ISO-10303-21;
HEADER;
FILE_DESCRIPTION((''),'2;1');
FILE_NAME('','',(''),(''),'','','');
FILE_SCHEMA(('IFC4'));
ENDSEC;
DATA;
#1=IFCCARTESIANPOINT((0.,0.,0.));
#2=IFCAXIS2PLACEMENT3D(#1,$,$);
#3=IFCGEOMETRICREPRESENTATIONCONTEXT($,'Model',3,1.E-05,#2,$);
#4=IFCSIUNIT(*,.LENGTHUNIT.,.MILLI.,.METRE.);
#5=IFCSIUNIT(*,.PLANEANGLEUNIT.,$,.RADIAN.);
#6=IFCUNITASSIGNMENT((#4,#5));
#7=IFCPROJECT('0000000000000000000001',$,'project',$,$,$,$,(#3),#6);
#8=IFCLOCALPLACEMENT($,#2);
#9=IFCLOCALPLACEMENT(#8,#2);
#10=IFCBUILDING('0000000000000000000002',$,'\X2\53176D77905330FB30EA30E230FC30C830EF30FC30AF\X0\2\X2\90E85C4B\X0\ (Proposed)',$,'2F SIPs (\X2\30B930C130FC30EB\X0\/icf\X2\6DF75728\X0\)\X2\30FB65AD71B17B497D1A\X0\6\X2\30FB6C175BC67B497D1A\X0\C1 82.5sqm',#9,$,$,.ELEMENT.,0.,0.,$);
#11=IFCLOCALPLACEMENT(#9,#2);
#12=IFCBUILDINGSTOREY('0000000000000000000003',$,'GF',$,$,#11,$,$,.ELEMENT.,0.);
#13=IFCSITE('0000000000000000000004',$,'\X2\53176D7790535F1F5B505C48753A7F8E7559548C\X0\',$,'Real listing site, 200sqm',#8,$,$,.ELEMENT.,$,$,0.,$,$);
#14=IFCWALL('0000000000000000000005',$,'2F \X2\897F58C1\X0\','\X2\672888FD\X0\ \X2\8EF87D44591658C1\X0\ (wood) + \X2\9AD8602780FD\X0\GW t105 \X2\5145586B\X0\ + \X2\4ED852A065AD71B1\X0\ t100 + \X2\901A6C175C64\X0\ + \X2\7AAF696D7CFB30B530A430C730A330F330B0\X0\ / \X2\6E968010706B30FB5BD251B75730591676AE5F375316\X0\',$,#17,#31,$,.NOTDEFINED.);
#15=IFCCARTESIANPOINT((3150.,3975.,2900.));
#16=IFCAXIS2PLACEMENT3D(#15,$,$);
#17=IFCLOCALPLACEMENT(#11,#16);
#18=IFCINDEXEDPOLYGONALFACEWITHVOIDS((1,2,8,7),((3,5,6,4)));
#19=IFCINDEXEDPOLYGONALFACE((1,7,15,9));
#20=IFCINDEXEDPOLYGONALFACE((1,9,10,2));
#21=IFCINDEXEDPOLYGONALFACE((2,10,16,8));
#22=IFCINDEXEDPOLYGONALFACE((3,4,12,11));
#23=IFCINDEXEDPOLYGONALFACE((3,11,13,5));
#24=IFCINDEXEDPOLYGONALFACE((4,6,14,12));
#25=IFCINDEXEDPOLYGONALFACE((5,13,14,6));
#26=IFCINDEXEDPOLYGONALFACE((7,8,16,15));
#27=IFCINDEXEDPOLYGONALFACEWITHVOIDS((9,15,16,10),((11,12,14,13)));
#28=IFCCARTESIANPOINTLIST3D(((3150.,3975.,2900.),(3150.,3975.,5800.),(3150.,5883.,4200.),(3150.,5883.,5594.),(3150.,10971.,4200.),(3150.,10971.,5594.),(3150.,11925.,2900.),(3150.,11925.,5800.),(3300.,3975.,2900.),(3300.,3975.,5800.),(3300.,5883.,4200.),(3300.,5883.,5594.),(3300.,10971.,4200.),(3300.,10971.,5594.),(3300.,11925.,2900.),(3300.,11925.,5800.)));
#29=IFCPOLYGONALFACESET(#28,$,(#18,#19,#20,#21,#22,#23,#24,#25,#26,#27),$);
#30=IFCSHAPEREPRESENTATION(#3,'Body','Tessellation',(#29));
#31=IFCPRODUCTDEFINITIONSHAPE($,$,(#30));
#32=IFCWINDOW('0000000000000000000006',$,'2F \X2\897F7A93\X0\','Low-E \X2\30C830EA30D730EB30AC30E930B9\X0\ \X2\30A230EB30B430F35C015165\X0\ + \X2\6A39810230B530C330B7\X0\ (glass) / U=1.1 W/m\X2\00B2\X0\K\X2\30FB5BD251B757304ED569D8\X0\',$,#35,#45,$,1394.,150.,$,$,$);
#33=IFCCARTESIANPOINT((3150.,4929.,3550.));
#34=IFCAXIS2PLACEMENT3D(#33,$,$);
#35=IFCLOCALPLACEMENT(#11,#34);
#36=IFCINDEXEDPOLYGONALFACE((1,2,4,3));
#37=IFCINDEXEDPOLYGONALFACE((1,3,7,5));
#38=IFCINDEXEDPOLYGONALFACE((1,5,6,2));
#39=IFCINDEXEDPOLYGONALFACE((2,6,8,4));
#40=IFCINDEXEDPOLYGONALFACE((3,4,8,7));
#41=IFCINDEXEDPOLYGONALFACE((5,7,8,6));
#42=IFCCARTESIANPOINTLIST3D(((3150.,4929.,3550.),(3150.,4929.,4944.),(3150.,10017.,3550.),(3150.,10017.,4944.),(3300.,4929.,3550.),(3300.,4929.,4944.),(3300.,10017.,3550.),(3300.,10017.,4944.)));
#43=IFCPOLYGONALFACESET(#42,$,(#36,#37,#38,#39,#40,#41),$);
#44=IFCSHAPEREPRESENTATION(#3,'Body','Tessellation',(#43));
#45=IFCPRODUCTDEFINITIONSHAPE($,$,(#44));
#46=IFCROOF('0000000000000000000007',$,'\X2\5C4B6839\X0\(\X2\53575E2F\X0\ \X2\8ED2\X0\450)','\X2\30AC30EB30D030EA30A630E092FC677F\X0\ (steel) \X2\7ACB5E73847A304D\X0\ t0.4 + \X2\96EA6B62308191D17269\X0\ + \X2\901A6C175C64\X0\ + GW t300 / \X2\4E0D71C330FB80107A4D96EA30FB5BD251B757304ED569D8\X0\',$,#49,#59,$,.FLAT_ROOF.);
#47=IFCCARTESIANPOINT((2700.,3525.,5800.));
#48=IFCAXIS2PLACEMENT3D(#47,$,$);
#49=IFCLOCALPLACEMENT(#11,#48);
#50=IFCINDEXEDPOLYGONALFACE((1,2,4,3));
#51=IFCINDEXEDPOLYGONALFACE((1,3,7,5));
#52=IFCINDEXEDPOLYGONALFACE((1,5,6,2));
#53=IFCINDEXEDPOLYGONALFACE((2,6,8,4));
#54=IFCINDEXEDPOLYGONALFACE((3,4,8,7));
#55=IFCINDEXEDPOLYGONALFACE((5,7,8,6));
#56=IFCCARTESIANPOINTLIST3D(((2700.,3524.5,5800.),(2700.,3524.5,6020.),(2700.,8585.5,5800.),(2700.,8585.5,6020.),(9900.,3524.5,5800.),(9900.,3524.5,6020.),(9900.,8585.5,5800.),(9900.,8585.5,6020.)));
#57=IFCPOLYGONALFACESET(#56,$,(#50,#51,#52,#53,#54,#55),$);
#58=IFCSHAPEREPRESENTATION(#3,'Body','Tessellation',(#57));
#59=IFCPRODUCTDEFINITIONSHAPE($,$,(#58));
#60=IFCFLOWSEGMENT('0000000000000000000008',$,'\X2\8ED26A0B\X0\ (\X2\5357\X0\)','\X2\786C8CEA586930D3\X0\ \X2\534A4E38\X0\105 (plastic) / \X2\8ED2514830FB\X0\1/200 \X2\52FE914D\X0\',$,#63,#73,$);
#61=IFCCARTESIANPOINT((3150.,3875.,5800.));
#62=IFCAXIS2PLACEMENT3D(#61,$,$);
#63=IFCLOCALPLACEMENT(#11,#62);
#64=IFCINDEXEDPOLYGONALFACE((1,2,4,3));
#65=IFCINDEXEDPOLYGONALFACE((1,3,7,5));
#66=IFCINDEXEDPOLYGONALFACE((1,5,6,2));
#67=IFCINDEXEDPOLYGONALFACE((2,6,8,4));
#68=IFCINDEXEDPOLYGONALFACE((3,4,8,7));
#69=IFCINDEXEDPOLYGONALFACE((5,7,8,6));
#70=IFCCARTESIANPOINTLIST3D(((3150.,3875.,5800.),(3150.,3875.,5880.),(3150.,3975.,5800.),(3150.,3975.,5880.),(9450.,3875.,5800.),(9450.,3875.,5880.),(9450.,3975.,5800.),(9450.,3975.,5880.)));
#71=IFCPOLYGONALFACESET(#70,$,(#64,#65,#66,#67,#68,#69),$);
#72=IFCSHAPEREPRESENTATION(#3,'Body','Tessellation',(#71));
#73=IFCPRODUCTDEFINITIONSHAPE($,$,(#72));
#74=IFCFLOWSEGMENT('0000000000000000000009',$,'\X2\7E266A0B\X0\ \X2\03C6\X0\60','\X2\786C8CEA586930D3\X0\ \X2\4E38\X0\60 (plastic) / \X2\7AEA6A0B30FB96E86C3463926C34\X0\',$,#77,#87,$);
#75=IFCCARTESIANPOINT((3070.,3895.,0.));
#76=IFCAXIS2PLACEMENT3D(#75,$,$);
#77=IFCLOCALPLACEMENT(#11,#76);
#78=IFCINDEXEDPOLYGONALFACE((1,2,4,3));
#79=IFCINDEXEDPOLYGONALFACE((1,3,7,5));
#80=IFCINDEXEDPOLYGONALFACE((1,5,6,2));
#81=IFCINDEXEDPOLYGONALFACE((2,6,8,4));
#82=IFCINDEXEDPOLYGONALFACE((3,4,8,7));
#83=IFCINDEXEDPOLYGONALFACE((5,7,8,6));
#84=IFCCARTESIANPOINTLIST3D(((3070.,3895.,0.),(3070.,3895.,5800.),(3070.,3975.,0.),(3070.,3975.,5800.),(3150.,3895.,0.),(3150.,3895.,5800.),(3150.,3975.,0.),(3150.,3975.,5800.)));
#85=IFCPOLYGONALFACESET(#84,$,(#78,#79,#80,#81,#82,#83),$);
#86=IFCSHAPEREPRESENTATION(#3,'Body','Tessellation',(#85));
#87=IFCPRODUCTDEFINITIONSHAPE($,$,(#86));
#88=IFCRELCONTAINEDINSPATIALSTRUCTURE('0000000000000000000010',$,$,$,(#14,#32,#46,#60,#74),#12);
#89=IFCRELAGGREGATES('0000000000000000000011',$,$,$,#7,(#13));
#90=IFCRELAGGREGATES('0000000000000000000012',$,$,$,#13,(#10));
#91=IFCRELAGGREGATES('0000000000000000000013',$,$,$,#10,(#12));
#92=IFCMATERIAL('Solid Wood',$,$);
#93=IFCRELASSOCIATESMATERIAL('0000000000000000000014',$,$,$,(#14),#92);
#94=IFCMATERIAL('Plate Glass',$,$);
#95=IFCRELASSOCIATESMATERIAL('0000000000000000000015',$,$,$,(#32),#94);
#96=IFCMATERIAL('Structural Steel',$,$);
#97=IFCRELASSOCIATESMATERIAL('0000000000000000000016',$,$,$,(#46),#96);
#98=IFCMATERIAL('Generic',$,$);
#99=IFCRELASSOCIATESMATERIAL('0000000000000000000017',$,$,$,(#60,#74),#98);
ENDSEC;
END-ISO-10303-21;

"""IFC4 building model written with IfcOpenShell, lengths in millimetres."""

from ifc_helpers import new_model, si_unit, frame, frame_2d, origin, place, context, project, spatial, rectangle, extrude, material, element, fill, save


model = new_model("IFC4")

# Units and contexts
model_context = context("Model", 3, precision=1e-05, world=origin())
ifc_project = project(units=[si_unit("LENGTHUNIT", "METRE", prefix="MILLI"), si_unit("PLANEANGLEUNIT", "RADIAN")], contexts=[model_context])

# Site, building, storey
site_placement = place(None, origin())
site = spatial("IfcSite", under=ifc_project, at=site_placement, Name="北海道弟子屈町美留和", ObjectType="Real listing site, 200sqm", CompositionType="ELEMENT", RefElevation=0.0)
building_placement = place(site_placement, origin())
building = spatial("IfcBuilding", under=site, at=building_placement, Name="北海道・リモートワーク2部屋 (Proposed)", ObjectType="2F SIPs (スチール/icf混在)・断熱等級6・気密等級C1 82.5sqm", CompositionType="ELEMENT", ElevationOfRefHeight=0.0, ElevationOfTerrain=0.0)
storey_placement = place(building_placement, origin())
storey = spatial("IfcBuildingStorey", under=building, at=storey_placement, Name="GF", CompositionType="ELEMENT", Elevation=0.0)

# Shared definitions
ifc_material_1 = material(Name="Solid Wood")

# Shared definitions
ifc_material_2 = material(Name="Plate Glass")

# Wall, opening, window
wall_1_placement = place(storey_placement, frame((3150.0, 3975.0, 2900.0)))
wall_1 = element("IfcWall", 1, at=wall_1_placement, inside=storey, material=ifc_material_1, Name="2F 西壁", Description="木製 軸組外壁 (wood) + 高性能GW t105 充填 + 付加断熱 t100 + 通気層 + 窯業系サイディング / 準耐火・寒冷地外皮強化", PredefinedType="NOTDEFINED", context=model_context, shape_type="SweptSolid", body=[
    extrude(rectangle(XDim=150.0, YDim=7950.0, at=frame_2d((75.0, 3975.0))), frame((3150.0, 3975.0, 2900.0)), (0.0, 0.0, 1.0), 2900.0),
])
opening_1_placement = place(storey_placement, frame((3150.0, 4929.0, 3550.0)))
opening_1 = element("IfcOpeningElement", 2, at=opening_1_placement, cuts=wall_1, PredefinedType="NOTDEFINED", context=model_context, shape_type="SweptSolid", body=[
    extrude(rectangle(XDim=150.0, YDim=5088.0, at=frame_2d((75.0, 2544.0))), frame((3150.0, 4929.0, 3550.0)), (0.0, 0.0, 1.0), 1394.0),
])
window_1_placement = place(storey_placement, frame((3150.0, 4929.0, 3550.0)))
window_1 = element("IfcWindow", 3, at=window_1_placement, inside=storey, material=ifc_material_2, Name="2F 西窓", Description="Low-E トリプルガラス アルゴン封入 + 樹脂サッシ (glass) / U=1.1 W/m²K・寒冷地仕様", OverallHeight=1394.0, OverallWidth=150.0, context=model_context, shape_type="SweptSolid", body=[
    extrude(rectangle(XDim=150.0, YDim=5088.0, at=frame_2d((75.0, 2544.0))), frame((3150.0, 4929.0, 3550.0)), (0.0, 0.0, 1.0), 1394.0),
])
fill(opening_1, window_1)

# Roof
ifc_material_3 = material(Name="Structural Steel")
for number, where, name in (
    (4, (2700.0, 3525.0, 5800.0), "屋根(南帯 軒450)"),
):
    element("IfcRoof", number, at=place(storey_placement, frame(where)), inside=storey, material=ifc_material_3, Name=name, Description="ガルバリウム鋼板 (steel) 立平葺き t0.4 + 雪止め金物 + 通気層 + GW t300 / 不燃・耐積雪・寒冷地仕様", PredefinedType="FLAT_ROOF", context=model_context, shape_type="SweptSolid", body=[
        extrude(rectangle(XDim=7200.0, YDim=5061.0, at=frame_2d((3600.0, 2530.0))), frame((2700.0, 3525.0, 5800.0)), (0.0, 0.0, 1.0), 220.0),
    ])

# Flow segments
ifc_material_4 = material(Name="Generic")
flow_segment_1_placement = place(storey_placement, frame((3150.0, 3875.0, 5800.0)))
element("IfcFlowSegment", 5, at=flow_segment_1_placement, inside=storey, material=ifc_material_4, Name="軒樋 (南)", Description="硬質塩ビ 半丸105 (plastic) / 軒先・1/200 勾配", context=model_context, shape_type="SweptSolid", body=[
    extrude(rectangle(XDim=6300.0, YDim=100.0, at=frame_2d((3150.0, 50.0))), frame((3150.0, 3875.0, 5800.0)), (0.0, 0.0, 1.0), 80.0),
])
flow_segment_2_placement = place(storey_placement, frame((3070.0, 3895.0, 0.0)))
element("IfcFlowSegment", 6, at=flow_segment_2_placement, inside=storey, material=ifc_material_4, Name="縦樋 φ60", Description="硬質塩ビ 丸60 (plastic) / 竪樋・雨水排水", context=model_context, shape_type="SweptSolid", body=[
    extrude(rectangle(XDim=80.0, YDim=80.0, at=frame_2d((40.0, 40.0))), frame((3070.0, 3895.0, 0.0)), (0.0, 0.0, 1.0), 5800.0),
])

save(model, "model.ifc")
